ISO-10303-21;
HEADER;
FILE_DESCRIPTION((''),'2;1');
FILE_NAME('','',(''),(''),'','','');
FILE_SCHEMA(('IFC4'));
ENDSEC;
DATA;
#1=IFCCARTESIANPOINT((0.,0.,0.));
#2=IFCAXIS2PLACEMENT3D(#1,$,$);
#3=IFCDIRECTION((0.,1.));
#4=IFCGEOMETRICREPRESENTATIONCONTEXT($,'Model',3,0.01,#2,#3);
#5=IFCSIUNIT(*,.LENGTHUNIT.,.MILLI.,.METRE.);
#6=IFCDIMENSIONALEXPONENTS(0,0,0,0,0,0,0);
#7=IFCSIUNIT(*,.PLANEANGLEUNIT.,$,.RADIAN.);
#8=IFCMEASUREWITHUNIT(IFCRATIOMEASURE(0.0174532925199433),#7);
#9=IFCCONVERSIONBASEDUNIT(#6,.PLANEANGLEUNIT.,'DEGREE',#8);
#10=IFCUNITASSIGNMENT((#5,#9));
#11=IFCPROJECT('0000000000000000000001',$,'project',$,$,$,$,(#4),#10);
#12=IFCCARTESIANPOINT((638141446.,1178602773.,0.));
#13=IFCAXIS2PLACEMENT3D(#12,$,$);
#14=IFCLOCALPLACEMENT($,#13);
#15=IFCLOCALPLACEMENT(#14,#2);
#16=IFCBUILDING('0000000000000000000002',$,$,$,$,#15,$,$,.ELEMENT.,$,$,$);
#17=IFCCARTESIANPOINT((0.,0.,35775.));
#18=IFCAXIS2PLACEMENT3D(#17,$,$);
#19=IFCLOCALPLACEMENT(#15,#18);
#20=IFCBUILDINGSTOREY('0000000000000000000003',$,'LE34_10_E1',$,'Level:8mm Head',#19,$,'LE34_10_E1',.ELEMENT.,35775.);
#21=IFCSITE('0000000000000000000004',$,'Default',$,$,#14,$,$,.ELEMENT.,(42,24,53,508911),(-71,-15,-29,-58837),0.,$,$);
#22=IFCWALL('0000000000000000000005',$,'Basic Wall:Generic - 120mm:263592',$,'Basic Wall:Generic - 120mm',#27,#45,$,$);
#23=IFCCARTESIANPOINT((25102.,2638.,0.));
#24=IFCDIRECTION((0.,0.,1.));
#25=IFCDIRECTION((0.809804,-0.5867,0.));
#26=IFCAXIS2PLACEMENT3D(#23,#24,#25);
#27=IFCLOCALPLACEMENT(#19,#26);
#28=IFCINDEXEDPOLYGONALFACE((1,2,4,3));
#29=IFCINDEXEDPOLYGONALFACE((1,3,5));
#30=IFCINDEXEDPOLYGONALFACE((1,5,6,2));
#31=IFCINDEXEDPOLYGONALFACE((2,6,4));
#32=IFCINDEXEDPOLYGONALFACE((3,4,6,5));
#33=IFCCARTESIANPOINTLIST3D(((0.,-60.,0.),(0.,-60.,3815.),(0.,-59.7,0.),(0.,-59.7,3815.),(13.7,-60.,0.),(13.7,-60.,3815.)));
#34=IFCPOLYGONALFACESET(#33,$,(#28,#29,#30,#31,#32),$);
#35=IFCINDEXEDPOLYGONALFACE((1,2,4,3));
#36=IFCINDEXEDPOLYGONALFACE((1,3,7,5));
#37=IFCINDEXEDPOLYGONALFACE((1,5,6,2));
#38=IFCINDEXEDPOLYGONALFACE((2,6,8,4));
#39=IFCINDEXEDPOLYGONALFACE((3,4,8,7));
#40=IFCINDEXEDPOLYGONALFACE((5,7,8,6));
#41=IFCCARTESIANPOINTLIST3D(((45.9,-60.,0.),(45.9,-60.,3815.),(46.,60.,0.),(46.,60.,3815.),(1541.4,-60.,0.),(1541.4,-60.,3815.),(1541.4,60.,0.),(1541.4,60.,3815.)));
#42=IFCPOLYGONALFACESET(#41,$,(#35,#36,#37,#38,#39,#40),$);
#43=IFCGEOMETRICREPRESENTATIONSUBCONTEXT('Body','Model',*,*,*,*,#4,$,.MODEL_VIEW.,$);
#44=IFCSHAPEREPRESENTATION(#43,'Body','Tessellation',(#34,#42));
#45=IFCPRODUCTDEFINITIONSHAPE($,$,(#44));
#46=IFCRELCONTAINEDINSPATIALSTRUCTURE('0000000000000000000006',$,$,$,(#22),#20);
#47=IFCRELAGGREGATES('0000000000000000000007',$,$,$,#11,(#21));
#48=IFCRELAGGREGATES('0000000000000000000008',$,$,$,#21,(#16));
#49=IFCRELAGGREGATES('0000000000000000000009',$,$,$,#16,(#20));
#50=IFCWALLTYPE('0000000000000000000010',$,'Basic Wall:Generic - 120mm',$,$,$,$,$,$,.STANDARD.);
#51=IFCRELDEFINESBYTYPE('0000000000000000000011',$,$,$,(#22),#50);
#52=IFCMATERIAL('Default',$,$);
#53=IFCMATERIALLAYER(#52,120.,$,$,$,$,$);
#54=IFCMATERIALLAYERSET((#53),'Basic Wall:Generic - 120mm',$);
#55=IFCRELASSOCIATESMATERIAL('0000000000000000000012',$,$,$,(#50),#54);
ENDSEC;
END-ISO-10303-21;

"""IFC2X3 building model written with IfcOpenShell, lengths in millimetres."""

from ifc_helpers import new_model, entity, si_unit, converted_unit, direction, frame, origin, place, context, subcontext, project, spatial, polyline, outline, extrude, material, layer, layer_set, type_object, element, save


model = new_model("IFC2X3")

# Units and contexts
model_context = context("Model", 3, precision=0.01, world=origin(), true_north=direction((0.0, 1.0)))
body_context = subcontext(model_context, "Body", "Model", "MODEL_VIEW")
ifc_project = project(units=[si_unit("LENGTHUNIT", "METRE", prefix="MILLI"), converted_unit("PLANEANGLEUNIT", "DEGREE", entity("IfcRatioMeasure", 0.0174532925199433), si_unit("PLANEANGLEUNIT", "RADIAN"), dimensions=[0, 0, 0, 0, 0, 0, 0])], contexts=[model_context])

# Site, building, storey
site_placement = place(None, frame((638141446.0, 1178602773.0, 0.0)))
site = spatial("IfcSite", under=ifc_project, at=site_placement, Name="Default", CompositionType="ELEMENT", RefLatitude=(42, 24, 53, 508911), RefLongitude=(-71, -15, -29, -58837), RefElevation=0.0)
building_placement = place(site_placement, origin())
building = spatial("IfcBuilding", under=site, at=building_placement, CompositionType="ELEMENT")
storey_placement = place(building_placement, frame((0.0, 0.0, 35775.0)))
storey = spatial("IfcBuildingStorey", under=building, at=storey_placement, Name="LE34_10_E1", ObjectType="Level:8mm Head", LongName="LE34_10_E1", CompositionType="ELEMENT", Elevation=35775.0)

# Shared definitions
ifc_material_1 = material(Name="Default")

# Shared definitions
ifc_layer_1 = layer(ifc_material_1, 120.0)
ifc_layer_set_1 = layer_set([ifc_layer_1], Name="Basic Wall:Generic - 120mm")
wall_type_1 = type_object("IfcWallType", Name="Basic Wall:Generic - 120mm", PredefinedType="STANDARD", material=ifc_layer_set_1)

# Wall
wall_1_placement = place(storey_placement, frame((25102.0, 2638.0, 0.0), z_axis=(0.0, 0.0, 1.0), x_axis=(0.809804, -0.5867, 0.0)))
element("IfcWall", 1, at=wall_1_placement, inside=storey, type_object=wall_type_1, Name="Basic Wall:Generic - 120mm:263592", ObjectType="Basic Wall:Generic - 120mm", context=body_context, shape_type="SweptSolid", body=[
    extrude(outline(polyline([(-9.1, -0.1), (4.6, -0.1), (4.5, 0.2), (-9.1, -0.1)])), frame((4.6, -59.9, 0.0), z_axis=(0.0, 0.0, 1.0), x_axis=(-0.999808, 0.019579, 0.0)), (0.0, 0.0, 1.0), 3815.0),
    extrude(outline(polyline([(-747.7, -60.0), (747.7, -60.0), (747.8, 60.0), (-747.7, 60.0), (-747.7, -60.0)])), frame((793.7, 0.0, 0.0), z_axis=(0.0, 0.0, 1.0), x_axis=(-1.0, 0.0, 0.0)), (0.0, 0.0, 1.0), 3815.0),
])

save(model, "model.ifc")
